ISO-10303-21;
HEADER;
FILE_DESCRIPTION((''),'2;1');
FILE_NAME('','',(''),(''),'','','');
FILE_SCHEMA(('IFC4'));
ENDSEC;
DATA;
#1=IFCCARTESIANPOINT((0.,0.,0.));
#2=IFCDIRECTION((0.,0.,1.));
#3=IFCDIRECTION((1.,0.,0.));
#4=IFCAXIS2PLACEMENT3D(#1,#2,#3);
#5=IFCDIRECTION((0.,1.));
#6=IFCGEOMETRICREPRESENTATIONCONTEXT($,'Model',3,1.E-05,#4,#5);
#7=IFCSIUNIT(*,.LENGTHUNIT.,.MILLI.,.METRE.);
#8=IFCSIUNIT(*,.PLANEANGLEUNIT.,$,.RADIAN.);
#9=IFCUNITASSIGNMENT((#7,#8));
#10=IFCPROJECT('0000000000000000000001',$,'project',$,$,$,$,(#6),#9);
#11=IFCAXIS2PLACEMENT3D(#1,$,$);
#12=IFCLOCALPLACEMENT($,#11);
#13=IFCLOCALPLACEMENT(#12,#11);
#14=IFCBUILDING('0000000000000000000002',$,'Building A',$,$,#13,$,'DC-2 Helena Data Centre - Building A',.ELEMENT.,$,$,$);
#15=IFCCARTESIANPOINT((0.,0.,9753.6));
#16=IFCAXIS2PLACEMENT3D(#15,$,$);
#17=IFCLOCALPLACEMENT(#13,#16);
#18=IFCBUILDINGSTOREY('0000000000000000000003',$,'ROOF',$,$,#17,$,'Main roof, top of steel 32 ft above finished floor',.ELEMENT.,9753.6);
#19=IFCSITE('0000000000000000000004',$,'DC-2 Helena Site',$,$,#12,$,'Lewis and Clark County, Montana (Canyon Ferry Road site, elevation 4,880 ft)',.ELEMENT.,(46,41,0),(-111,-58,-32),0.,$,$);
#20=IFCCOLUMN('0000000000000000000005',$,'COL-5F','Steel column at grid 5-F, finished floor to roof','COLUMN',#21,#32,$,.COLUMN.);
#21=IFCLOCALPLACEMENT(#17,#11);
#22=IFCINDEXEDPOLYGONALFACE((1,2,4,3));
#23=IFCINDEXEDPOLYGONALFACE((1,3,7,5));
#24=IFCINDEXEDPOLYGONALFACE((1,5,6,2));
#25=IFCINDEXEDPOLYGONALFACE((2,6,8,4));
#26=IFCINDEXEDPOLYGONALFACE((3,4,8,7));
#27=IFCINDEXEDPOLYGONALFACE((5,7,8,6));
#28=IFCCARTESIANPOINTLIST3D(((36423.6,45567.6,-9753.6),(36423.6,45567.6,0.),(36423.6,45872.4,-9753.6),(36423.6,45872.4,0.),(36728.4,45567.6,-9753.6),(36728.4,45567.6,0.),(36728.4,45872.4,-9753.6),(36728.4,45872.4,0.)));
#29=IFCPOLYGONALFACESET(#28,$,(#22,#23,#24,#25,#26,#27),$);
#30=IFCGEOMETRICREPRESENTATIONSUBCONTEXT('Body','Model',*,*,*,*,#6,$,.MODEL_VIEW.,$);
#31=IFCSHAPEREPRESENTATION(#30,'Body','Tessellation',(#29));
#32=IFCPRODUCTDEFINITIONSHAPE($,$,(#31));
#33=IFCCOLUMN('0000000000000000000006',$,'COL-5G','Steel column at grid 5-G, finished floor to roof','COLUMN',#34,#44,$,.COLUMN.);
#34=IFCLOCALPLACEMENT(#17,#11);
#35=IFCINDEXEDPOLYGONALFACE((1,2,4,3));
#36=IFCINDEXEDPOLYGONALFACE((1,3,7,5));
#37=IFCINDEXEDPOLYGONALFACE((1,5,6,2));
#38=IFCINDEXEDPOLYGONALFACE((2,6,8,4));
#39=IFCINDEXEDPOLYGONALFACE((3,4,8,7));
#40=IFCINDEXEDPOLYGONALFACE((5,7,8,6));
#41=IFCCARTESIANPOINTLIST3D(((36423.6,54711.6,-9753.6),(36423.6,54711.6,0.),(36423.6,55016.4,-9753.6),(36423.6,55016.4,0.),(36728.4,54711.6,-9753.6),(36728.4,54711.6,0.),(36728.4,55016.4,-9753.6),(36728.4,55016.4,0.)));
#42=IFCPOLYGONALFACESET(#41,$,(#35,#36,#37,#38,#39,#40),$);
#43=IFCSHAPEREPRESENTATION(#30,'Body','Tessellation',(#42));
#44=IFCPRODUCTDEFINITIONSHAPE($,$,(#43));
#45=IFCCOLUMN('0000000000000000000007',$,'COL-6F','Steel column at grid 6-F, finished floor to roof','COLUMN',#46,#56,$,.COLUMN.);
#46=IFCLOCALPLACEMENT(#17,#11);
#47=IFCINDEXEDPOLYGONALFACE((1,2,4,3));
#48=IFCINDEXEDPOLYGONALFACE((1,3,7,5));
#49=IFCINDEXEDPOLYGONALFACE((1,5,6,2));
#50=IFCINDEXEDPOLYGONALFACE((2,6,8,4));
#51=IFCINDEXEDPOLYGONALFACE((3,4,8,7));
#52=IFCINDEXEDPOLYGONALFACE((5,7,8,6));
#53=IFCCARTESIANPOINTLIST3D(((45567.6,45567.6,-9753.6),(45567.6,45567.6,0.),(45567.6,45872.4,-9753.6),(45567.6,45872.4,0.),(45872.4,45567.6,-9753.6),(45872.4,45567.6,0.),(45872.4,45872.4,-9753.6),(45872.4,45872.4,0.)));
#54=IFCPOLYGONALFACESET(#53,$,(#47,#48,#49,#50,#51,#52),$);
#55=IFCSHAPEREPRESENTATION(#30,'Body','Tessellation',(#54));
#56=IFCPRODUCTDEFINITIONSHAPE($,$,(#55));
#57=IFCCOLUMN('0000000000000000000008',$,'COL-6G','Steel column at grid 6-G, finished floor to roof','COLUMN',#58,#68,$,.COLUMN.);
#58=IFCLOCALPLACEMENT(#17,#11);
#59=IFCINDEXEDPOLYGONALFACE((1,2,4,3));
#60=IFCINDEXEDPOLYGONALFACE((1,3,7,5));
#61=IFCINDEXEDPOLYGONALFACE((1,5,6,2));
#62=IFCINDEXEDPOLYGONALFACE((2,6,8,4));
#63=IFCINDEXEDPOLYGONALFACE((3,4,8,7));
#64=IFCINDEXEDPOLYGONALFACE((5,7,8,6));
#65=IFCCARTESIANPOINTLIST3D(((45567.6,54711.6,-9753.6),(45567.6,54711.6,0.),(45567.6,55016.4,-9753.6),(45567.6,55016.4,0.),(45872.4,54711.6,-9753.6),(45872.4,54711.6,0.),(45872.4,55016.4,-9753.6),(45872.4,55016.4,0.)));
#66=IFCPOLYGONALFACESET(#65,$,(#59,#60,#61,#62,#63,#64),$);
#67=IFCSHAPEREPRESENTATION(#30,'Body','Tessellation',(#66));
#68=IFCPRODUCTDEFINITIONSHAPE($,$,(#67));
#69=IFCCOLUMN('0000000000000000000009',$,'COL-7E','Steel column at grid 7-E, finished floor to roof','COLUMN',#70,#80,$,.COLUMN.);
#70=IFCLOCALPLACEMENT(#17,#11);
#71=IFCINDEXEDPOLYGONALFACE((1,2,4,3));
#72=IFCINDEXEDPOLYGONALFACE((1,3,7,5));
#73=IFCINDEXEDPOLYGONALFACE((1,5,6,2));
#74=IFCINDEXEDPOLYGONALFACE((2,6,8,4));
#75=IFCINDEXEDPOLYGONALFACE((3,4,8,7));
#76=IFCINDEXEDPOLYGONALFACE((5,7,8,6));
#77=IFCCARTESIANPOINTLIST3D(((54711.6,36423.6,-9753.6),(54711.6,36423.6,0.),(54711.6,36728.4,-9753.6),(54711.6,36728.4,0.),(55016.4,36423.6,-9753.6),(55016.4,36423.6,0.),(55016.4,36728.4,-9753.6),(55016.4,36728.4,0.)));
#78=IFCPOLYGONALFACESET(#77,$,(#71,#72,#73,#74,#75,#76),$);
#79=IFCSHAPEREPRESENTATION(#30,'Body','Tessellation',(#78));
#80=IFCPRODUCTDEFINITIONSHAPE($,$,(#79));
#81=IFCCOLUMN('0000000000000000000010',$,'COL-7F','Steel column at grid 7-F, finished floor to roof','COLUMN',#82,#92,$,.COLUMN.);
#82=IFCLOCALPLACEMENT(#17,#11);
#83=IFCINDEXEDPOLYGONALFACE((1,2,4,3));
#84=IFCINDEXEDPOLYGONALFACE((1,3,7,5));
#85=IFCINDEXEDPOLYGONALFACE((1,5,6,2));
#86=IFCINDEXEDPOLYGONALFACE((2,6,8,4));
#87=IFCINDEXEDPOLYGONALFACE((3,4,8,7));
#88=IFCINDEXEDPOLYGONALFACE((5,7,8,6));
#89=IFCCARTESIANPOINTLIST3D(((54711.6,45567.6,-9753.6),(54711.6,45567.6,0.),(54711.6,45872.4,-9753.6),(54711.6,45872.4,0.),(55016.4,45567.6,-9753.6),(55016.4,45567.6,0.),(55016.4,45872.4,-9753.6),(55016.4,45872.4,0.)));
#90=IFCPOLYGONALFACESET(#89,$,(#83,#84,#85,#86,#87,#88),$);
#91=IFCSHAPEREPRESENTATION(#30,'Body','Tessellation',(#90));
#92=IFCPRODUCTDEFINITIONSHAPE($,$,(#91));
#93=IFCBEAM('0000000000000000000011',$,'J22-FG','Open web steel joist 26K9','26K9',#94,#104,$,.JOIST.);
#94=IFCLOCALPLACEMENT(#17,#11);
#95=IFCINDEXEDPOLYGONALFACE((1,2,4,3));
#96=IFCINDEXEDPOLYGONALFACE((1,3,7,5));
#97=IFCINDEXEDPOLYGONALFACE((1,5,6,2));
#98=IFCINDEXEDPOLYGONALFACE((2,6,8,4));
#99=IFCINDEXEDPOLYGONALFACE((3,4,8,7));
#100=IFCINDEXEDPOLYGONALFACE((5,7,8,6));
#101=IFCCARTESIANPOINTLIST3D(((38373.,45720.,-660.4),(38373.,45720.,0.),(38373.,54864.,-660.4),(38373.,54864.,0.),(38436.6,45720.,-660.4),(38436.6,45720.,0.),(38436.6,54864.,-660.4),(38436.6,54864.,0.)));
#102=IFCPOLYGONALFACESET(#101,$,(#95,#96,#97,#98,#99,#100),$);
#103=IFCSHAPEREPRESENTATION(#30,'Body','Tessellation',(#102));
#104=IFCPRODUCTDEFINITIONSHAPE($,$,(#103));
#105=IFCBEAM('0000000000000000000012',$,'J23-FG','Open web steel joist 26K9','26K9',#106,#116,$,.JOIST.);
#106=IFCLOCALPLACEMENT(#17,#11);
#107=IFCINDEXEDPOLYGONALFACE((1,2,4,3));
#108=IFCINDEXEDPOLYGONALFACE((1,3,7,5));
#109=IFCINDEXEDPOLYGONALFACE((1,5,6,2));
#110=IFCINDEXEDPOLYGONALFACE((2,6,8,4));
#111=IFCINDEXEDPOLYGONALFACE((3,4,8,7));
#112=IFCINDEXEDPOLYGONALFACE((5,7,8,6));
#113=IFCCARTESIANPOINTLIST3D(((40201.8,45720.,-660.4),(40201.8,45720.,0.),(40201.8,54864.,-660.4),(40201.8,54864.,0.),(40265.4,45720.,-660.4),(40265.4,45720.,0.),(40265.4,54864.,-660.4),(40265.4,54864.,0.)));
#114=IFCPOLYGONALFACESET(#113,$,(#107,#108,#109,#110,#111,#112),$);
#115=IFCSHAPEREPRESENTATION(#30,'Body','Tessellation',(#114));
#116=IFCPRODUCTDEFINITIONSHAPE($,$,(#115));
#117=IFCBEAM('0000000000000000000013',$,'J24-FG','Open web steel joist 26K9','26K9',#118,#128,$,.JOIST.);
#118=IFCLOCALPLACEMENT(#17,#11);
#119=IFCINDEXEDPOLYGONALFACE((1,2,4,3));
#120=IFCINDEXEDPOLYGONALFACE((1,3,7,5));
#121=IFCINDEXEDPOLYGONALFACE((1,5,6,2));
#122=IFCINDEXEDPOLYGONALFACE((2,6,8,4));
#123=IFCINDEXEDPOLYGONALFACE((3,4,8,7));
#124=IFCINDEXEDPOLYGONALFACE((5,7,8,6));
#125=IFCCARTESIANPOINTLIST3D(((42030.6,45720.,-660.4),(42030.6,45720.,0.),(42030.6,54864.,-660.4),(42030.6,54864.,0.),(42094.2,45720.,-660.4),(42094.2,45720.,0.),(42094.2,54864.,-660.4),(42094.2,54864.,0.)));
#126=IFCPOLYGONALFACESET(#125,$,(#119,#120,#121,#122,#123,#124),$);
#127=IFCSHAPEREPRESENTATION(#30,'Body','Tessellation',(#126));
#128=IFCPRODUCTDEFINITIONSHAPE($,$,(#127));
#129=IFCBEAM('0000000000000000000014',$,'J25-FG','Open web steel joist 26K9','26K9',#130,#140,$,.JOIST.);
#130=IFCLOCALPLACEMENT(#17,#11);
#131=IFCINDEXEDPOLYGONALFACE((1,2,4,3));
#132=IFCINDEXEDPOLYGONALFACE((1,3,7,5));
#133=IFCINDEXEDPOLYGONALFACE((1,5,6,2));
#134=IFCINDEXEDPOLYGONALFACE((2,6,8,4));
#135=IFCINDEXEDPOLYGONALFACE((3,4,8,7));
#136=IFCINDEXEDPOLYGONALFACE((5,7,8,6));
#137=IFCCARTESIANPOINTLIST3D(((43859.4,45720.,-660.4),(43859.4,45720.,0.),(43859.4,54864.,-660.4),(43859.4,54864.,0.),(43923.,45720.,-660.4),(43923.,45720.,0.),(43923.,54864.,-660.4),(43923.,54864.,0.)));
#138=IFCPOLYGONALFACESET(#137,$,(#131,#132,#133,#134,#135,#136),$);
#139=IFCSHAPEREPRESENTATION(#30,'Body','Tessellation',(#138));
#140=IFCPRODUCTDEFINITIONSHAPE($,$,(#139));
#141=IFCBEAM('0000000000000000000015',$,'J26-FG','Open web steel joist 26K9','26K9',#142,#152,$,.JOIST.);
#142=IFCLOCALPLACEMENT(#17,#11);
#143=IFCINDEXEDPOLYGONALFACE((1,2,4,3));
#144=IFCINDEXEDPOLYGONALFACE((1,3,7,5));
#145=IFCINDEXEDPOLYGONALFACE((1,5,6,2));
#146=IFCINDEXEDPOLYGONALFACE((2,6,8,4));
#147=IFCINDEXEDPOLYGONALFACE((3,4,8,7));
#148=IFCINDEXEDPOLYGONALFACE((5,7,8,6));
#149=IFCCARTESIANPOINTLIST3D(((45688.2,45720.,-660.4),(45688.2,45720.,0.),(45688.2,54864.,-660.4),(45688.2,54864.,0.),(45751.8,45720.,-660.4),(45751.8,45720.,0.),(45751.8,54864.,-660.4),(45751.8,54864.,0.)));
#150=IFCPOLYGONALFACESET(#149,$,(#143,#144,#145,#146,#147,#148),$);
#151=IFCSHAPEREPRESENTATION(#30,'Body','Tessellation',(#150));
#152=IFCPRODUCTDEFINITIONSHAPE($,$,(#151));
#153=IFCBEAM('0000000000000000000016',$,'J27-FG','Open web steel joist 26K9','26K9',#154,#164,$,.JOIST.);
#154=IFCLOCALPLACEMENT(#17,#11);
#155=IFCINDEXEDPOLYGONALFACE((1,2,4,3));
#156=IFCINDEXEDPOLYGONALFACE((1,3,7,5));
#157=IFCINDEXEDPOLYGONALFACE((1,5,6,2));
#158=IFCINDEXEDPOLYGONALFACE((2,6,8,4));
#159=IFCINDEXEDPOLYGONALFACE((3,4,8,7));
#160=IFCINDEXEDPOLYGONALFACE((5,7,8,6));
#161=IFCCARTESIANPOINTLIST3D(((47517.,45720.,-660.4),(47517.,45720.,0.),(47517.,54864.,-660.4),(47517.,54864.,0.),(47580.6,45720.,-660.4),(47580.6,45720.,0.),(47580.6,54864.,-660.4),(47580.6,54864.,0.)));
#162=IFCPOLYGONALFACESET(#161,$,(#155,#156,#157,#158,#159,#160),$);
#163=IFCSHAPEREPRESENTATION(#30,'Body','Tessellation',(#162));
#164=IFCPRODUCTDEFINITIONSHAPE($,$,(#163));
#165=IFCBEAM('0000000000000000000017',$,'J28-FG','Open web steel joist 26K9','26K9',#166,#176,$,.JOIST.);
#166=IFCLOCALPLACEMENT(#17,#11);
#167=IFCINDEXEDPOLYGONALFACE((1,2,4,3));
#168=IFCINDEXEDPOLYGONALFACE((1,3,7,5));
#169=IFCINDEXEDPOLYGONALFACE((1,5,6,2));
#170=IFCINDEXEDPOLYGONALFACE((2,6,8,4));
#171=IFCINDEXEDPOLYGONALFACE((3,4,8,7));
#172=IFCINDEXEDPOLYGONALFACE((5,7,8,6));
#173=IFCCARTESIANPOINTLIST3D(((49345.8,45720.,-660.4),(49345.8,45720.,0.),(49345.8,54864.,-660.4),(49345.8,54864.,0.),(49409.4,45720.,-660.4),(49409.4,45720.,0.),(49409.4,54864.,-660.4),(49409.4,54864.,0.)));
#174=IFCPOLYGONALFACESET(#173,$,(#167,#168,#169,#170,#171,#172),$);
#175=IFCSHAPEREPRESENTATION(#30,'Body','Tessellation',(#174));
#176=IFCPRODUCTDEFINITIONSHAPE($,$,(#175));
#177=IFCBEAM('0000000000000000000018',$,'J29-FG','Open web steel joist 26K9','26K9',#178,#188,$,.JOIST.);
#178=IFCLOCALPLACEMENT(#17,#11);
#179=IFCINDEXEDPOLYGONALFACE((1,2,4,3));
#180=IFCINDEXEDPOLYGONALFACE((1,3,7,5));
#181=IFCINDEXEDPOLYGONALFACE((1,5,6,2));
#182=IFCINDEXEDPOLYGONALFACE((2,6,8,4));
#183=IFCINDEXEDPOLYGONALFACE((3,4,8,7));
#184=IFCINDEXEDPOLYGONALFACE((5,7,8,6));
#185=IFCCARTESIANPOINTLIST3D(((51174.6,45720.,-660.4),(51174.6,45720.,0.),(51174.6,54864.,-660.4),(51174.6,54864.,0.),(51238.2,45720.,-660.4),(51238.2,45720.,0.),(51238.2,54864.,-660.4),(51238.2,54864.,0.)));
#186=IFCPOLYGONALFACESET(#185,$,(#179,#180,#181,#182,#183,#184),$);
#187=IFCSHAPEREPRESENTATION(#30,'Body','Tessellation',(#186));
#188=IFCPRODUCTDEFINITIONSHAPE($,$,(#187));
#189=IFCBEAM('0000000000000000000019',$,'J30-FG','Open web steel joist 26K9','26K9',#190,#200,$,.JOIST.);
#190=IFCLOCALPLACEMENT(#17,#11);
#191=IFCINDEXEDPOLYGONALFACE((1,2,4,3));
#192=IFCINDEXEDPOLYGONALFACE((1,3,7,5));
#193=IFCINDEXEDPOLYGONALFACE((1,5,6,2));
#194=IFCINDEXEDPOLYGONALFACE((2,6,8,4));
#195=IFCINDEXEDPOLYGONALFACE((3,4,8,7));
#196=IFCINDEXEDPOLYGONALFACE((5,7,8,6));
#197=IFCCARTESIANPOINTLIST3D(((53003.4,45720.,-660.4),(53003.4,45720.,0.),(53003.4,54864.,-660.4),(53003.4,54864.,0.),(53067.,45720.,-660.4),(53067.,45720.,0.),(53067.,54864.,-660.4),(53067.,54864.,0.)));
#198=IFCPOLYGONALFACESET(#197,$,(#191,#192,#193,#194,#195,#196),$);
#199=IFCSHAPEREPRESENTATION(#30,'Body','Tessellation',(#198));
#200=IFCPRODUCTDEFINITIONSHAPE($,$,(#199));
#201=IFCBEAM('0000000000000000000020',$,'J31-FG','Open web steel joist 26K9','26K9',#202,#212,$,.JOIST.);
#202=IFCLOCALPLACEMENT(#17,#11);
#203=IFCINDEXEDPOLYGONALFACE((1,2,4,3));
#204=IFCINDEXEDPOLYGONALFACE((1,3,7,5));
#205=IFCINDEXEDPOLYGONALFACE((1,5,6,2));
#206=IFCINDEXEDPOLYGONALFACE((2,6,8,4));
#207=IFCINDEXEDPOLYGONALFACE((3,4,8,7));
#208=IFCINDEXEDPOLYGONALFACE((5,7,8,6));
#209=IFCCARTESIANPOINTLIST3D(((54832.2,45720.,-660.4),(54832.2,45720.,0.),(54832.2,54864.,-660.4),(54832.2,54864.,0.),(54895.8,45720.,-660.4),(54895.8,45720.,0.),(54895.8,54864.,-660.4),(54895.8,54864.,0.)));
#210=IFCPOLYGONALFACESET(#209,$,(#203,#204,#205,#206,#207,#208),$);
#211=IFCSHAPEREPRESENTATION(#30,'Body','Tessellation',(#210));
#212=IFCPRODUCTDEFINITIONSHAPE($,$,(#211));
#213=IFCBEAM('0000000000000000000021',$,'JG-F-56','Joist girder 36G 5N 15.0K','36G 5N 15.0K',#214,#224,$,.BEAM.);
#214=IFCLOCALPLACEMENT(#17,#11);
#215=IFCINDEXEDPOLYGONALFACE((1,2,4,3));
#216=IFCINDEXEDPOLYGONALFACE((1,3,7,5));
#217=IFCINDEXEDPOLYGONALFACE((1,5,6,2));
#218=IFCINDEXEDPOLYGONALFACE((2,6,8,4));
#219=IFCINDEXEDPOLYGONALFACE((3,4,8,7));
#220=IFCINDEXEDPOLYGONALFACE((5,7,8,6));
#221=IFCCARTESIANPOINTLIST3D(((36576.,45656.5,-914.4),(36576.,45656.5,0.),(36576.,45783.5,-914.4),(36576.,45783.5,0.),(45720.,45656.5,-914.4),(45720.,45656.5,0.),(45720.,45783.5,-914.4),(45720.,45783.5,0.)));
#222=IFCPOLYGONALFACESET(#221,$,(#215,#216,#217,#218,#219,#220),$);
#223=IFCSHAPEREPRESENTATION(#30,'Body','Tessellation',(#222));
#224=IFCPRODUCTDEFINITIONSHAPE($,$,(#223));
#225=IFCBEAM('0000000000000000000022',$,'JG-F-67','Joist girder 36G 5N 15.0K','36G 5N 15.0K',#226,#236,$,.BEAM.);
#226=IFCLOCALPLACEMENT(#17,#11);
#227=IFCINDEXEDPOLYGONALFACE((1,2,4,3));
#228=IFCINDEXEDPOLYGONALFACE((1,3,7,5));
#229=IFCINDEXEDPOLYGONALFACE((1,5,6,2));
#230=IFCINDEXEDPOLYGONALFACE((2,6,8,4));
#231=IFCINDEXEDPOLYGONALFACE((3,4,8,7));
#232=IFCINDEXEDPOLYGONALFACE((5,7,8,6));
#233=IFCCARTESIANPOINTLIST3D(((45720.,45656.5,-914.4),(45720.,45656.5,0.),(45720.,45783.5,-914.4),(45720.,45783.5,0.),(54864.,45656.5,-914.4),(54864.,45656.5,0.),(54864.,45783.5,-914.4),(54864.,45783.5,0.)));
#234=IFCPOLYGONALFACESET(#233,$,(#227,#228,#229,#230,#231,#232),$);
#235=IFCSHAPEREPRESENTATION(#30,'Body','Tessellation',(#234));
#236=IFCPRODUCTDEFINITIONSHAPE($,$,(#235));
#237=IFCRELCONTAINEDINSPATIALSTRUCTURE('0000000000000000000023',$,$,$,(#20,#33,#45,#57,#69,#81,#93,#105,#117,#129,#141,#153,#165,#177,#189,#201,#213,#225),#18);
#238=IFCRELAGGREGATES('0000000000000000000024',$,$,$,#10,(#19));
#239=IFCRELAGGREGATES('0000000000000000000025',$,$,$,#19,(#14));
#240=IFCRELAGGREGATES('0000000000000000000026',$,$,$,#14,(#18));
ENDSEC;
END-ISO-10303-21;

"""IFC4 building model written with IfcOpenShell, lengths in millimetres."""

from ifc_helpers import new_model, si_unit, direction, frame, origin, origin_with_axes, origin_2d, place, context, subcontext, project, spatial, rectangle, extrude, element, save


model = new_model("IFC4")

# Units and contexts
model_context = context("Model", 3, precision=1e-05, world=origin_with_axes(), true_north=direction((0.0, 1.0)))
body_context = subcontext(model_context, "Body", "Model", "MODEL_VIEW")
ifc_project = project(units=[si_unit("LENGTHUNIT", "METRE", prefix="MILLI"), si_unit("PLANEANGLEUNIT", "RADIAN")], contexts=[model_context])

# Site, building, storey
site_placement = place(None, origin())
site = spatial("IfcSite", under=ifc_project, at=site_placement, Name="DC-2 Helena Site", LongName="Lewis and Clark County, Montana (Canyon Ferry Road site, elevation 4,880 ft)", CompositionType="ELEMENT", RefLatitude=(46, 41, 0), RefLongitude=(-111, -58, -32), RefElevation=0.0)
building_placement = place(site_placement, origin())
building = spatial("IfcBuilding", under=site, at=building_placement, Name="Building A", LongName="DC-2 Helena Data Centre - Building A", CompositionType="ELEMENT")
storey_placement = place(building_placement, frame((0.0, 0.0, 9753.6)))
storey = spatial("IfcBuildingStorey", under=building, at=storey_placement, Name="ROOF", LongName="Main roof, top of steel 32 ft above finished floor", CompositionType="ELEMENT", Elevation=9753.6)

# Columns
for number, where, name, description in (
    (1, (36576.0, 45720.0, -9753.6), "COL-5F", "Steel column at grid 5-F, finished floor to roof"),
    (2, (36576.0, 54864.0, -9753.6), "COL-5G", "Steel column at grid 5-G, finished floor to roof"),
    (3, (45720.0, 45720.0, -9753.6), "COL-6F", "Steel column at grid 6-F, finished floor to roof"),
):
    element("IfcColumn", number, at=place(storey_placement, frame(where)), inside=storey, Name=name, Description=description, ObjectType="COLUMN", PredefinedType="COLUMN", context=body_context, shape_type="SweptSolid", body=[
        extrude(rectangle(XDim=304.8, YDim=304.8, at=origin_2d()), origin(), (0.0, 0.0, 1.0), 9753.6),
    ])
placement_1 = place(storey_placement, frame((45720.0, 54864.0, -9753.6)))
element("IfcColumn", 4, at=placement_1, inside=storey, Name="COL-6G", Description="Steel column at grid 6-G, finished floor to roof", ObjectType="COLUMN", PredefinedType="COLUMN", context=body_context, shape_type="SweptSolid", body=[
    extrude(rectangle(XDim=304.8, YDim=304.8, at=origin_2d()), origin(), (0.0, 0.0, 1.0), 9753.6),
])
for number, where, name, description in (
    (5, (54864.0, 36576.0, -9753.6), "COL-7E", "Steel column at grid 7-E, finished floor to roof"),
    (6, (54864.0, 45720.0, -9753.6), "COL-7F", "Steel column at grid 7-F, finished floor to roof"),
):
    element("IfcColumn", number, at=place(storey_placement, frame(where)), inside=storey, Name=name, Description=description, ObjectType="COLUMN", PredefinedType="COLUMN", context=body_context, shape_type="SweptSolid", body=[
        extrude(rectangle(XDim=304.8, YDim=304.8, at=origin_2d()), origin(), (0.0, 0.0, 1.0), 9753.6),
    ])

# Beams
for number, where, name in (
    (7, (38404.8, 45720.0, 0.0), "J22-FG"),
    (8, (40233.6, 45720.0, 0.0), "J23-FG"),
    (9, (42062.4, 45720.0, 0.0), "J24-FG"),
    (10, (43891.2, 45720.0, 0.0), "J25-FG"),
):
    element("IfcBeam", number, at=place(storey_placement, frame(where)), inside=storey, Name=name, Description="Open web steel joist 26K9", ObjectType="26K9", PredefinedType="JOIST", context=body_context, shape_type="SweptSolid", body=[
        extrude(rectangle(XDim=63.5, YDim=660.4, at=origin_2d()), frame((0.0, 0.0, -330.2), z_axis=(0.0, 1.0, 0.0), x_axis=(1.0, 0.0, 0.0)), (0.0, 0.0, 1.0), 9144.0),
    ])
placement_2 = place(storey_placement, frame((45720.0, 45720.0, 0.0)))
element("IfcBeam", 11, at=placement_2, inside=storey, Name="J26-FG", Description="Open web steel joist 26K9", ObjectType="26K9", PredefinedType="JOIST", context=body_context, shape_type="SweptSolid", body=[
    extrude(rectangle(XDim=63.5, YDim=660.4, at=origin_2d()), frame((0.0, 0.0, -330.2), z_axis=(0.0, 1.0, 0.0), x_axis=(1.0, 0.0, 0.0)), (0.0, 0.0, 1.0), 9144.0),
])
for number, where, name in (
    (12, (47548.8, 45720.0, 0.0), "J27-FG"),
    (13, (49377.6, 45720.0, 0.0), "J28-FG"),
    (14, (51206.4, 45720.0, 0.0), "J29-FG"),
    (15, (53035.2, 45720.0, 0.0), "J30-FG"),
):
    element("IfcBeam", number, at=place(storey_placement, frame(where)), inside=storey, Name=name, Description="Open web steel joist 26K9", ObjectType="26K9", PredefinedType="JOIST", context=body_context, shape_type="SweptSolid", body=[
        extrude(rectangle(XDim=63.5, YDim=660.4, at=origin_2d()), frame((0.0, 0.0, -330.2), z_axis=(0.0, 1.0, 0.0), x_axis=(1.0, 0.0, 0.0)), (0.0, 0.0, 1.0), 9144.0),
    ])
placement_3 = place(storey_placement, frame((54864.0, 45720.0, 0.0)))
element("IfcBeam", 16, at=placement_3, inside=storey, Name="J31-FG", Description="Open web steel joist 26K9", ObjectType="26K9", PredefinedType="JOIST", context=body_context, shape_type="SweptSolid", body=[
    extrude(rectangle(XDim=63.5, YDim=660.4, at=origin_2d()), frame((0.0, 0.0, -330.2), z_axis=(0.0, 1.0, 0.0), x_axis=(1.0, 0.0, 0.0)), (0.0, 0.0, 1.0), 9144.0),
])
beam_1_placement = place(storey_placement, frame((36576.0, 45720.0, 0.0)))
element("IfcBeam", 17, at=beam_1_placement, inside=storey, Name="JG-F-56", Description="Joist girder 36G 5N 15.0K", ObjectType="36G 5N 15.0K", PredefinedType="BEAM", context=body_context, shape_type="SweptSolid", body=[
    extrude(rectangle(XDim=127.0, YDim=914.4, at=origin_2d()), frame((0.0, 0.0, -457.2), z_axis=(1.0, 0.0, 0.0), x_axis=(0.0, 1.0, 0.0)), (0.0, 0.0, 1.0), 9144.0),
])
element("IfcBeam", 18, at=placement_2, inside=storey, Name="JG-F-67", Description="Joist girder 36G 5N 15.0K", ObjectType="36G 5N 15.0K", PredefinedType="BEAM", context=body_context, shape_type="SweptSolid", body=[
    extrude(rectangle(XDim=127.0, YDim=914.4, at=origin_2d()), frame((0.0, 0.0, -457.2), z_axis=(1.0, 0.0, 0.0), x_axis=(0.0, 1.0, 0.0)), (0.0, 0.0, 1.0), 9144.0),
])

save(model, "model.ifc")
